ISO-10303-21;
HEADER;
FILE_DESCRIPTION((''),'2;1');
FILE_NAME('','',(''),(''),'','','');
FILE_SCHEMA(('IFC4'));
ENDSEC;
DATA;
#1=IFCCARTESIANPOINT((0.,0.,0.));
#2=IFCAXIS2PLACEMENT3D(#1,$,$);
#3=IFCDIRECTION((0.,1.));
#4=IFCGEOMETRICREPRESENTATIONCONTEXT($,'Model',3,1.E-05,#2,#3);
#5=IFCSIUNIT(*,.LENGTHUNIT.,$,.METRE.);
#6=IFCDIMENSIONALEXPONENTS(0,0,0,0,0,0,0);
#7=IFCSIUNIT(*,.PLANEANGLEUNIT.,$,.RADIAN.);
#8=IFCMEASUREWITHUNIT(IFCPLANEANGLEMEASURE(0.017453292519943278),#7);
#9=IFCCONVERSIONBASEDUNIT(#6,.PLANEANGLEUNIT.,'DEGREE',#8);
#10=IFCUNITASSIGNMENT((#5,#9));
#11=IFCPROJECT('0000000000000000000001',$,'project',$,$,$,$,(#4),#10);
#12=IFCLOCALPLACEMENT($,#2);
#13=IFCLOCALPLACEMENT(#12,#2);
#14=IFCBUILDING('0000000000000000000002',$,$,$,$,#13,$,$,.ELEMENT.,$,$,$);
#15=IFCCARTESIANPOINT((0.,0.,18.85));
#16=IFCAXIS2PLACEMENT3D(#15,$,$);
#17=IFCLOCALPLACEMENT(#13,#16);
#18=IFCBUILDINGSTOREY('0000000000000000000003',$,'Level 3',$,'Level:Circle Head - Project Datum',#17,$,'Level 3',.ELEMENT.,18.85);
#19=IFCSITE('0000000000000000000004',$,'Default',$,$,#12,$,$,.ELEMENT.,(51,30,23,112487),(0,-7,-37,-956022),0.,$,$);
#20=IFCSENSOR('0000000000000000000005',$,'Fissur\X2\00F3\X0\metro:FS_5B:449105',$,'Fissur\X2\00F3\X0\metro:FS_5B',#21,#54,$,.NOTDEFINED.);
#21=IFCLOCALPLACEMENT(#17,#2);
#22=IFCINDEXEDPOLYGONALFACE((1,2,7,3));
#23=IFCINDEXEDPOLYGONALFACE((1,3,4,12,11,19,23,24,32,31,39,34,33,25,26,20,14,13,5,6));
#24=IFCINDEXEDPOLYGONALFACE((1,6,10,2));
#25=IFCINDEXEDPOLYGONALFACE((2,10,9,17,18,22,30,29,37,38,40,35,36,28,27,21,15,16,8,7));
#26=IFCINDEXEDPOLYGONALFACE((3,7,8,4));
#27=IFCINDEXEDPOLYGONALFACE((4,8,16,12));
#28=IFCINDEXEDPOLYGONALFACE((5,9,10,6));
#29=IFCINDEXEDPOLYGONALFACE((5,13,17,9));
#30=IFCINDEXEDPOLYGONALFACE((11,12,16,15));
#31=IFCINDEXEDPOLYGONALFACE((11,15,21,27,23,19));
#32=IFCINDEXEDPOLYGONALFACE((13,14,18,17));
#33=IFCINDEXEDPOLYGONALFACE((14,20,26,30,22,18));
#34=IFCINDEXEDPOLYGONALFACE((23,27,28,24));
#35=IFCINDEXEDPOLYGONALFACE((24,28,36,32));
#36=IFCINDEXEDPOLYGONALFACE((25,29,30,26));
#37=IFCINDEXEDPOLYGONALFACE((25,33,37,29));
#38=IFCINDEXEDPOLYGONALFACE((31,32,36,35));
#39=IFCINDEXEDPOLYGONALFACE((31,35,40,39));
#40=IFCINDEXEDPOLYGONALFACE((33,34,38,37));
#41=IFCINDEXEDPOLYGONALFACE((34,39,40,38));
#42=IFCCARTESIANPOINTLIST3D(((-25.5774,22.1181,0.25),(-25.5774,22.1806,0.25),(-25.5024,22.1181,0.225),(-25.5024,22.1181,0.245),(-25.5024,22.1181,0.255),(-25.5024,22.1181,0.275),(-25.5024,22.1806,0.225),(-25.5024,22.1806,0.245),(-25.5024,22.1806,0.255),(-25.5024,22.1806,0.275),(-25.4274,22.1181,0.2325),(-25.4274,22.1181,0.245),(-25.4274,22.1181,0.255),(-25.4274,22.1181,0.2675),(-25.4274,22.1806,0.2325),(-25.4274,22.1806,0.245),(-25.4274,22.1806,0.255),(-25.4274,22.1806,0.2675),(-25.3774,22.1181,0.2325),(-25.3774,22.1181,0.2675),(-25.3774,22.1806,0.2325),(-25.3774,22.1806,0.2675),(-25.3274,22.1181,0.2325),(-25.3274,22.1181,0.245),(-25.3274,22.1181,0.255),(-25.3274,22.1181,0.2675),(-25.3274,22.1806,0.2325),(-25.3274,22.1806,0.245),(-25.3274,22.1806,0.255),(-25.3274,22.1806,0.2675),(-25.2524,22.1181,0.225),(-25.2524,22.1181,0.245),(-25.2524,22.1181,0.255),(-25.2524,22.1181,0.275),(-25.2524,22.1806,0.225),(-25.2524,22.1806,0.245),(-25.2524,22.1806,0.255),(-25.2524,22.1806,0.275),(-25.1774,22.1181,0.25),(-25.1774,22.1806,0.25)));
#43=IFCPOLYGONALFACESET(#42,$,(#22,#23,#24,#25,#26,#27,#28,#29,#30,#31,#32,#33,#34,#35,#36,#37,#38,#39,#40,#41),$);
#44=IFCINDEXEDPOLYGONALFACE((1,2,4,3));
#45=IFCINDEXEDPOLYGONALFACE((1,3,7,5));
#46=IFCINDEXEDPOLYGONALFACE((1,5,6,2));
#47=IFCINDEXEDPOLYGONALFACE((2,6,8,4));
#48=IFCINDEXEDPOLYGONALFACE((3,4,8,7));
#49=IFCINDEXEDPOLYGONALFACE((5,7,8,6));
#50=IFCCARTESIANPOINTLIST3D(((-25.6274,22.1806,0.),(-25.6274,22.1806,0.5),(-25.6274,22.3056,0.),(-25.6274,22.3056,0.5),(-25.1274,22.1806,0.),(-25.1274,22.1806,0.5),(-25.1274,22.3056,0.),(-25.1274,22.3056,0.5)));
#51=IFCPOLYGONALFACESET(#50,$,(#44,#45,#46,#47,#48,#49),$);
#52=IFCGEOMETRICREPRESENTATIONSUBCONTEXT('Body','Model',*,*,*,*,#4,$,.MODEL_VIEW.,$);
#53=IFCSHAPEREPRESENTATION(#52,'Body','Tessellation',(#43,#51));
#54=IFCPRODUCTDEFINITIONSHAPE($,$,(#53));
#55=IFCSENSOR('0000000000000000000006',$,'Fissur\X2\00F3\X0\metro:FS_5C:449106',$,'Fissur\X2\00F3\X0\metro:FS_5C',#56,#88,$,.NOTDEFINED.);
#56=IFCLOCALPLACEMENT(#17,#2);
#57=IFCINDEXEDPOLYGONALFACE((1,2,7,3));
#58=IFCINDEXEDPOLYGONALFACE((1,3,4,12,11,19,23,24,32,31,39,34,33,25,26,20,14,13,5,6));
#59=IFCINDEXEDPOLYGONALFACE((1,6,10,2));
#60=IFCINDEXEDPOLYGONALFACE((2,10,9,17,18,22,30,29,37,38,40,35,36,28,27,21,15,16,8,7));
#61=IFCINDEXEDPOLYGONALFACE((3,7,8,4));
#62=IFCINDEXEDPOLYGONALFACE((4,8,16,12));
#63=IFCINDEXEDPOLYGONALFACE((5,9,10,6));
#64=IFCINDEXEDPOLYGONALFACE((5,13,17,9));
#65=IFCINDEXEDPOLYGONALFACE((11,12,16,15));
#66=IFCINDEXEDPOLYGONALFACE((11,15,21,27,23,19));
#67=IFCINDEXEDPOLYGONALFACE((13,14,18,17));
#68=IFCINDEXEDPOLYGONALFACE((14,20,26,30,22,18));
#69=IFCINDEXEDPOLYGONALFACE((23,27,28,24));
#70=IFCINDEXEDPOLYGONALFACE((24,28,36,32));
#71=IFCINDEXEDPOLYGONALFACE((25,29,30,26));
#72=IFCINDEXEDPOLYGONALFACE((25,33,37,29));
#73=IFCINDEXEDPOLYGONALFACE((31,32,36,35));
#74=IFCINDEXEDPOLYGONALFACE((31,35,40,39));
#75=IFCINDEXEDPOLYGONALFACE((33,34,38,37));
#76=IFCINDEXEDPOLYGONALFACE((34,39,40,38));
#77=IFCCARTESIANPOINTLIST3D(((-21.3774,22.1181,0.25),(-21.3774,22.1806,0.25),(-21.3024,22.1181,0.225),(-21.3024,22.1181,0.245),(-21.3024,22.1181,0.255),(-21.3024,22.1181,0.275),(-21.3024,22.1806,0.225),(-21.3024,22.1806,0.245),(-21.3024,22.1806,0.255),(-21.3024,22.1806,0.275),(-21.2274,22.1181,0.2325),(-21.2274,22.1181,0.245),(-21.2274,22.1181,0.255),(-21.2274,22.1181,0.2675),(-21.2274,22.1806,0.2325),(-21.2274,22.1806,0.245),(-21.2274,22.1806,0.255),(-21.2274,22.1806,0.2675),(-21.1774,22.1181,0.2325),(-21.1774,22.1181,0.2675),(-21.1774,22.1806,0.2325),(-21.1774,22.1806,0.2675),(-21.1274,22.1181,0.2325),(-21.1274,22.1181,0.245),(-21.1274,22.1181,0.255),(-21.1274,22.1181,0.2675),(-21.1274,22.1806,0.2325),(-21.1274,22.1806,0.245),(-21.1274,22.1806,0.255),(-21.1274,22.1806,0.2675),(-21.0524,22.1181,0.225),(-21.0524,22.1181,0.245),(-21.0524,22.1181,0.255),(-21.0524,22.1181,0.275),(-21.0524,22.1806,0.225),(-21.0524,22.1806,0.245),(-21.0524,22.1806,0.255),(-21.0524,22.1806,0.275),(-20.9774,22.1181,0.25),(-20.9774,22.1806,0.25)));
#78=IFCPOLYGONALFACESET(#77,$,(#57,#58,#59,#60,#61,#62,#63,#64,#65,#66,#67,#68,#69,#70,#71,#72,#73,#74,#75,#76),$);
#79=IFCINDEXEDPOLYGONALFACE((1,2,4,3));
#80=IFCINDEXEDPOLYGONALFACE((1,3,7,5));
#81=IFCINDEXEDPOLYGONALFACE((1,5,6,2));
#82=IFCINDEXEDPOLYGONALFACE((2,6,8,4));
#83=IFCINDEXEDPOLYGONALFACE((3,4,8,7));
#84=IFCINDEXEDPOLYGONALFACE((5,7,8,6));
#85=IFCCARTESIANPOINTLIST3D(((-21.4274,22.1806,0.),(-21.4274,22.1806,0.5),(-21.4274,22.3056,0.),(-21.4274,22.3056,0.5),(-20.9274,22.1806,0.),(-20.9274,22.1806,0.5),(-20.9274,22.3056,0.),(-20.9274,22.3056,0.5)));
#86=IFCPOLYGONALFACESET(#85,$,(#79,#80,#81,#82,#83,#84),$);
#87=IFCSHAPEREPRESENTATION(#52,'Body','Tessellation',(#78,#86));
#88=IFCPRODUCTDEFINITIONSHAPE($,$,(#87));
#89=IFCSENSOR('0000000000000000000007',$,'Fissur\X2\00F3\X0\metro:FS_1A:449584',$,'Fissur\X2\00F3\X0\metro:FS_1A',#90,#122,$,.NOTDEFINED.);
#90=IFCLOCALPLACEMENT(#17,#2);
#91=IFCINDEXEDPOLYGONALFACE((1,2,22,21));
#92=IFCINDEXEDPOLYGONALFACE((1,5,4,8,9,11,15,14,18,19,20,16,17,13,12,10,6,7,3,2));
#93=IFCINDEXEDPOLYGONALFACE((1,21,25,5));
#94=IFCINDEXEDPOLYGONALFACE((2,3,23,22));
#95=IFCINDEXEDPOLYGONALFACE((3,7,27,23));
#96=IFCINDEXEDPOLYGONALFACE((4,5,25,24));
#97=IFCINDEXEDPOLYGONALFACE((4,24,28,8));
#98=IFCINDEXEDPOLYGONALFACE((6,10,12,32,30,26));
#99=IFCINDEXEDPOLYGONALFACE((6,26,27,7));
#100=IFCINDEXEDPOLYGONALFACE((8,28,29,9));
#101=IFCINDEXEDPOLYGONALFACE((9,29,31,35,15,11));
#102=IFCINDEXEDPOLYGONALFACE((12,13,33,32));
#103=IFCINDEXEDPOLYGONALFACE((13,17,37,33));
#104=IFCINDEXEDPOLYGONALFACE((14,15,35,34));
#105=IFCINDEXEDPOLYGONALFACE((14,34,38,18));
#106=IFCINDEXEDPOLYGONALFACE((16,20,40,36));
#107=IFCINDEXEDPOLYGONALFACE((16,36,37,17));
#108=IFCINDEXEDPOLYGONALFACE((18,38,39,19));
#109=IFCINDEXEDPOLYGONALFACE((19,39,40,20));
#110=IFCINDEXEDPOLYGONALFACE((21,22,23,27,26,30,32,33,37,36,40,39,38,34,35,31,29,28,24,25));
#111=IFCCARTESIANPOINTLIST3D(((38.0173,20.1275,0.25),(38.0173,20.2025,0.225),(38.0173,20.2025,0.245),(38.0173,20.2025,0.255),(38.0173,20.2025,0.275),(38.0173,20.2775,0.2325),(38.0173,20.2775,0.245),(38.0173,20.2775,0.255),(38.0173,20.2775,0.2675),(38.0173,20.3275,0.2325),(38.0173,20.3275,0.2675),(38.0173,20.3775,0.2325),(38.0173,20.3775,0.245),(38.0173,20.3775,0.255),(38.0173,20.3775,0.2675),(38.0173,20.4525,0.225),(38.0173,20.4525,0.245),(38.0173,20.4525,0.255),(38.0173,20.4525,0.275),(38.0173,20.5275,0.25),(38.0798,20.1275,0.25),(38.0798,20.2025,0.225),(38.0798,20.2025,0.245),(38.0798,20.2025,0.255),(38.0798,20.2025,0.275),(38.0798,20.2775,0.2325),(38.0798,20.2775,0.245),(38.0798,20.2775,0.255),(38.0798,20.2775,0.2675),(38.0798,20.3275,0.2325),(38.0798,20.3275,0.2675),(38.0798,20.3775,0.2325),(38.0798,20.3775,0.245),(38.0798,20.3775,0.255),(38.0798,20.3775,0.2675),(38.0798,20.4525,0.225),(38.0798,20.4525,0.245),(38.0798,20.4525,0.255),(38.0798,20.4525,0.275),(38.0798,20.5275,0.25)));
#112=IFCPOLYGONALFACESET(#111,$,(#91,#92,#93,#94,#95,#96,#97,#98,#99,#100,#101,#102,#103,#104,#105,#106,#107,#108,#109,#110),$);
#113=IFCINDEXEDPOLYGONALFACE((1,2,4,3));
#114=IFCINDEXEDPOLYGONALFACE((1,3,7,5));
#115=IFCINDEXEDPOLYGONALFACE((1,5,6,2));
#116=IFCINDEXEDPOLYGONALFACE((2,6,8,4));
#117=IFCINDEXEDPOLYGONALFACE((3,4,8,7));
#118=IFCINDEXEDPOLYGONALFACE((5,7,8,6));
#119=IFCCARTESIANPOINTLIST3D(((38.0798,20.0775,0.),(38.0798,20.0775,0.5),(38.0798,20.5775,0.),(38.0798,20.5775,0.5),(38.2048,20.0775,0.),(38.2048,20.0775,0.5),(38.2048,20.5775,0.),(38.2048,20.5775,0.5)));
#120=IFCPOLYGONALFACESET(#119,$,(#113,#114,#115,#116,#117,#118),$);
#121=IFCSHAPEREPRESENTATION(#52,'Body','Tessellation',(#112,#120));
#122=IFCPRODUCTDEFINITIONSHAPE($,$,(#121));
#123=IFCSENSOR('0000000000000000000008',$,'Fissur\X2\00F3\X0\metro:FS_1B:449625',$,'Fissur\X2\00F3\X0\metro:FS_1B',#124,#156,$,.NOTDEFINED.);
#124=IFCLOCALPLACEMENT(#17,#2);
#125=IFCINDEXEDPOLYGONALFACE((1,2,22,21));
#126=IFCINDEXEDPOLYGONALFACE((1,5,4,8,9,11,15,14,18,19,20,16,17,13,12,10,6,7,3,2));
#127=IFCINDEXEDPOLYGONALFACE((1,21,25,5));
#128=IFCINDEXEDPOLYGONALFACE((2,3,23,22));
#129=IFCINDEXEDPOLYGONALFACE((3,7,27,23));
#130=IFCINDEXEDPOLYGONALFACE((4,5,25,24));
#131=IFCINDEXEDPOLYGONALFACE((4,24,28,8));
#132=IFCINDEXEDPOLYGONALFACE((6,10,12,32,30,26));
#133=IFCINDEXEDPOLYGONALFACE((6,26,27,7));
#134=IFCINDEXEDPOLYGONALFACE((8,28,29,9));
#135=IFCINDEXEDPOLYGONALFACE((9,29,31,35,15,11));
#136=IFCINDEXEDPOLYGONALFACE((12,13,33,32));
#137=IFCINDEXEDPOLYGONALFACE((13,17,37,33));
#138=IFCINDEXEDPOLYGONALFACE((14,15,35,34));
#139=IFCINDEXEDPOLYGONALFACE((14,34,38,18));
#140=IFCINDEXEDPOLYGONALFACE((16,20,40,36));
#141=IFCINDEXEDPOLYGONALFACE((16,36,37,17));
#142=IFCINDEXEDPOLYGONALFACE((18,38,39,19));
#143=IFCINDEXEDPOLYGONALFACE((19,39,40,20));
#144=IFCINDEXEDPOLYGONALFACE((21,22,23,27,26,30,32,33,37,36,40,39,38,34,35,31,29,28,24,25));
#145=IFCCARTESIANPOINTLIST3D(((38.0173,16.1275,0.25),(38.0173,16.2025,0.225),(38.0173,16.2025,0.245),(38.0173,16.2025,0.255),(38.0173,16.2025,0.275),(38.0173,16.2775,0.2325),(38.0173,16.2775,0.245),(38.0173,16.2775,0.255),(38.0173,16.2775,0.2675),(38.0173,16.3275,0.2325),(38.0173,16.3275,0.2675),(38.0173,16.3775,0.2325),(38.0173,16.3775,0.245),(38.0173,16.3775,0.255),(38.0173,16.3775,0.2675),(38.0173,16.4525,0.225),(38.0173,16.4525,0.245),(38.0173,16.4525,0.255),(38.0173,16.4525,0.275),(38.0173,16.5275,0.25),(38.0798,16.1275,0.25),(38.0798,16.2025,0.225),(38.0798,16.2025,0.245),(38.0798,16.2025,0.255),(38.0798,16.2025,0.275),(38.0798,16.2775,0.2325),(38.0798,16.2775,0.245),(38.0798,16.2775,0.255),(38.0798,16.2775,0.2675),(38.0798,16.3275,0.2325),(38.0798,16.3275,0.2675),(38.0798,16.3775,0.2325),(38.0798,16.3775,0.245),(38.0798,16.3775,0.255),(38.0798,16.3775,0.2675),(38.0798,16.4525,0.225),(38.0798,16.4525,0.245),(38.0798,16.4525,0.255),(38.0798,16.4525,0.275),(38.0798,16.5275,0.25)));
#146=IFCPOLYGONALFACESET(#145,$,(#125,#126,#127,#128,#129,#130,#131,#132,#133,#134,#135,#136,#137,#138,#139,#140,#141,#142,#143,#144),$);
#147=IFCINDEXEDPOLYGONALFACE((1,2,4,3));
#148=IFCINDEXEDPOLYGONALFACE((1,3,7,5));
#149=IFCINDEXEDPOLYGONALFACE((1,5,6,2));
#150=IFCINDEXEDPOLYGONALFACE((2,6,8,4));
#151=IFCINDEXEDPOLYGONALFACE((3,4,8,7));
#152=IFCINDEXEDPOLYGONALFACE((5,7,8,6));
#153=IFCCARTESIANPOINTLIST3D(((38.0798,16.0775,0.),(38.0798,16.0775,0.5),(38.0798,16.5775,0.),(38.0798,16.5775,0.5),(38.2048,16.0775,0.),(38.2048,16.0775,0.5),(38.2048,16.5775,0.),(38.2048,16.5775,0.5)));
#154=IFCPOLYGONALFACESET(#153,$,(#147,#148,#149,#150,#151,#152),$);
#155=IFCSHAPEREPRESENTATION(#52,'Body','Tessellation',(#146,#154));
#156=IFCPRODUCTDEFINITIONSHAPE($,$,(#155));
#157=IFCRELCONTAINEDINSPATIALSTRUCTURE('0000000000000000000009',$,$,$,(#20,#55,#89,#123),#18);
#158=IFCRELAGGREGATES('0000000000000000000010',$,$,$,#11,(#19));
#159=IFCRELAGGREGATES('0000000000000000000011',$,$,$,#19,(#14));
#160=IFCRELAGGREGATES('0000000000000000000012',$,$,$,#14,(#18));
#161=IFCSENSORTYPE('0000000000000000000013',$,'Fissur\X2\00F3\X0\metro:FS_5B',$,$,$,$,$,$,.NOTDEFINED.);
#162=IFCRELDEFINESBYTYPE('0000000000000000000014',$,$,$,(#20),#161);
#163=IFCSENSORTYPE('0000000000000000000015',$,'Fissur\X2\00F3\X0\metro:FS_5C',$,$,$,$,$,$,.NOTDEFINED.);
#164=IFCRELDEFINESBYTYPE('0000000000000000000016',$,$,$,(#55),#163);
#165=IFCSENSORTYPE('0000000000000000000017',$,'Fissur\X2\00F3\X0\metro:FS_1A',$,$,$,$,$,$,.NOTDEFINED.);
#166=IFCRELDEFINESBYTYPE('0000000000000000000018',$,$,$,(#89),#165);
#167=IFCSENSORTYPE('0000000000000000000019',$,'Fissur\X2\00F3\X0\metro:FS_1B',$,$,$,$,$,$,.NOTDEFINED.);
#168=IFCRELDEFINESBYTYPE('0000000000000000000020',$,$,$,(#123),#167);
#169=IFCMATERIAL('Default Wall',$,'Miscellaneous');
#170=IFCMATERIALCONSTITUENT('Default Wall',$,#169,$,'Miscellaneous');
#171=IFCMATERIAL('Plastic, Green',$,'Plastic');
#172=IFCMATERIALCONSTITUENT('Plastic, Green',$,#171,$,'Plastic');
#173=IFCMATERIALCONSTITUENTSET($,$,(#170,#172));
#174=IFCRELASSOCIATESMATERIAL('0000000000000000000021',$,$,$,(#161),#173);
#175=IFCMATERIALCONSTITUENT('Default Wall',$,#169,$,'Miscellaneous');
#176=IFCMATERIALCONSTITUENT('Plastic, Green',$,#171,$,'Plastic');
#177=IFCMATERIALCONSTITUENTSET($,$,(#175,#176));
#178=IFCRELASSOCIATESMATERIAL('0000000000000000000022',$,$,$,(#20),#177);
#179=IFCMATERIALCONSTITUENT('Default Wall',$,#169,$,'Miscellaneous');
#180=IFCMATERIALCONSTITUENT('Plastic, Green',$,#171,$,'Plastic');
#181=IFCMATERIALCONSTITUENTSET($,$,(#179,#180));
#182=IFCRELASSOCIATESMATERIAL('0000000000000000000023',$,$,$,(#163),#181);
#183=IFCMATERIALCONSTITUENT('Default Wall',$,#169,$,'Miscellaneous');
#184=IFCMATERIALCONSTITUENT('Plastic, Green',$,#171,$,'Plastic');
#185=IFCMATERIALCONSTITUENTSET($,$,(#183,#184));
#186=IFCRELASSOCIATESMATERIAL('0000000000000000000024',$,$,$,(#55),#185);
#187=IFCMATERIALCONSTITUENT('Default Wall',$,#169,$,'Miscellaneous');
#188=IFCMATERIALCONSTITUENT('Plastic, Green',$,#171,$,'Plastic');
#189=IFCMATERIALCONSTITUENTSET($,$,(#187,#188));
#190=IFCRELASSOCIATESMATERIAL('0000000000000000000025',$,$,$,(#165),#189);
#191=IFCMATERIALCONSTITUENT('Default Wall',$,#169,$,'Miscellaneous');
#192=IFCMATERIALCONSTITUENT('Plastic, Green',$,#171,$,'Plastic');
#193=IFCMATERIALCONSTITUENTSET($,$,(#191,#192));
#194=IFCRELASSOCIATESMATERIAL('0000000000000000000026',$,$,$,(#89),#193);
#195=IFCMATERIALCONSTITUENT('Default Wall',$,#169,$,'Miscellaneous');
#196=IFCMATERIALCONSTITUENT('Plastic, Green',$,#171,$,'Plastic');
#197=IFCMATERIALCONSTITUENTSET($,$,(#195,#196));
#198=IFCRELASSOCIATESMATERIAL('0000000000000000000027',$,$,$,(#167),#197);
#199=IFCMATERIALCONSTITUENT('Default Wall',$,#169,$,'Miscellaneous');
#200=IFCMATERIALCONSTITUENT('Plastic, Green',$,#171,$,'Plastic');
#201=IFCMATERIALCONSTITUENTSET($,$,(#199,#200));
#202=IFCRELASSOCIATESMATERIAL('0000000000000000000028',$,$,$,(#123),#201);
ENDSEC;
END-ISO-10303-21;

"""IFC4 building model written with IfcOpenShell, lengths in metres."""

from ifc_helpers import new_model, entity, si_unit, converted_unit, direction, frame, origin, place, context, subcontext, project, spatial, indexed_curve, outline, extrude, source, transform, mapped, material, constituent, constituent_set, type_object, type_shapes, element, save


model = new_model("IFC4")

# Units and contexts
model_context = context("Model", 3, precision=1e-05, world=origin(), true_north=direction((0.0, 1.0)))
body_context = subcontext(model_context, "Body", "Model", "MODEL_VIEW")
ifc_project = project(units=[si_unit("LENGTHUNIT", "METRE"), converted_unit("PLANEANGLEUNIT", "DEGREE", entity("IfcPlaneAngleMeasure", 0.017453292519943278), si_unit("PLANEANGLEUNIT", "RADIAN"), dimensions=[0, 0, 0, 0, 0, 0, 0])], contexts=[model_context])

# Site, building, storey
site_placement = place(None, origin())
site = spatial("IfcSite", under=ifc_project, at=site_placement, Name="Default", CompositionType="ELEMENT", RefLatitude=(51, 30, 23, 112487), RefLongitude=(0, -7, -37, -956022), RefElevation=0.0)
building_placement = place(site_placement, origin())
building = spatial("IfcBuilding", under=site, at=building_placement, CompositionType="ELEMENT")
storey_placement = place(building_placement, frame((0.0, 0.0, 18.85)))
storey = spatial("IfcBuildingStorey", under=building, at=storey_placement, Name="Level 3", ObjectType="Level:Circle Head - Project Datum", LongName="Level 3", CompositionType="ELEMENT", Elevation=18.85)

# Sensors
ifc_material_1 = material(Name="Default Wall", Category="Miscellaneous")
ifc_material_2 = material(Name="Plastic, Green", Category="Plastic")
ifc_constituent_1 = constituent(ifc_material_1, Name="Default Wall", Category="Miscellaneous")
ifc_constituent_2 = constituent(ifc_material_2, Name="Plastic, Green", Category="Plastic")
ifc_constituent_set_1 = constituent_set(constituents=[ifc_constituent_1, ifc_constituent_2])
ifc_constituent_3 = constituent(ifc_material_1, Name="Default Wall", Category="Miscellaneous")
ifc_constituent_4 = constituent(ifc_material_2, Name="Plastic, Green", Category="Plastic")
ifc_constituent_set_2 = constituent_set(constituents=[ifc_constituent_3, ifc_constituent_4])
sensor_type_1 = type_object("IfcSensorType", Name="Fissurómetro:FS_5B", PredefinedType="NOTDEFINED", material=ifc_constituent_set_2)
shared_shape_1 = source(origin(), body_context, "Body", "SweptSolid", [
    extrude(outline(indexed_curve([(-0.025, -0.125), (0.0, -0.2), (0.025, -0.125), (0.005, -0.125), (0.005, -0.05), (0.0175, -0.05), (0.0175, 0.0), (0.0175, 0.05), (0.005, 0.05), (0.005, 0.125), (0.025, 0.125), (0.0, 0.2), (-0.025, 0.125), (-0.005, 0.125), (-0.005, 0.05), (-0.0175, 0.05), (-0.0175, 0.0), (-0.0175, -0.05), (-0.005, -0.05), (-0.005, -0.125), (-0.025, -0.125)], self_intersect=False)), frame((0.0, -0.125, 0.25), z_axis=(0.0, -1.0, 0.0), x_axis=(0.0, 0.0, -1.0)), (0.0, 0.0, -1.0), 0.0625),
    extrude(outline(indexed_curve([(-0.25, -0.0625), (0.25, -0.0625), (0.25, 0.0625), (-0.25, 0.0625), (-0.25, -0.0625)], self_intersect=False)), frame((0.0, 0.0, 0.0), z_axis=(0.0, 0.0, 1.0), x_axis=(-1.0, 0.0, 0.0)), (0.0, 0.0, 1.0), 0.5),
])
type_shapes(sensor_type_1, [shared_shape_1])
sensor_1_placement = place(storey_placement, frame((-25.3774, 22.2431, 0.0)))
element("IfcSensor", 1, at=sensor_1_placement, inside=storey, type_object=sensor_type_1, material=ifc_constituent_set_1, Name="Fissurómetro:FS_5B:449105", ObjectType="Fissurómetro:FS_5B", PredefinedType="NOTDEFINED", context=body_context, shape_type="MappedRepresentation", body=[
    mapped(shared_shape_1, transform((0.0, 0.0, 0.0), scale=1.0)),
])
ifc_constituent_5 = constituent(ifc_material_1, Name="Default Wall", Category="Miscellaneous")
ifc_constituent_6 = constituent(ifc_material_2, Name="Plastic, Green", Category="Plastic")
ifc_constituent_set_3 = constituent_set(constituents=[ifc_constituent_5, ifc_constituent_6])
ifc_constituent_7 = constituent(ifc_material_1, Name="Default Wall", Category="Miscellaneous")
ifc_constituent_8 = constituent(ifc_material_2, Name="Plastic, Green", Category="Plastic")
ifc_constituent_set_4 = constituent_set(constituents=[ifc_constituent_7, ifc_constituent_8])
sensor_type_2 = type_object("IfcSensorType", Name="Fissurómetro:FS_5C", PredefinedType="NOTDEFINED", material=ifc_constituent_set_4)
shared_shape_2 = source(origin(), body_context, "Body", "SweptSolid", [
    extrude(outline(indexed_curve([(-0.025, -0.125), (0.0, -0.2), (0.025, -0.125), (0.005, -0.125), (0.005, -0.05), (0.0175, -0.05), (0.0175, 0.0), (0.0175, 0.05), (0.005, 0.05), (0.005, 0.125), (0.025, 0.125), (0.0, 0.2), (-0.025, 0.125), (-0.005, 0.125), (-0.005, 0.05), (-0.0175, 0.05), (-0.0175, 0.0), (-0.0175, -0.05), (-0.005, -0.05), (-0.005, -0.125), (-0.025, -0.125)], self_intersect=False)), frame((0.0, -0.125, 0.25), z_axis=(0.0, -1.0, 0.0), x_axis=(0.0, 0.0, -1.0)), (0.0, 0.0, -1.0), 0.0625),
    extrude(outline(indexed_curve([(-0.25, -0.0625), (0.25, -0.0625), (0.25, 0.0625), (-0.25, 0.0625), (-0.25, -0.0625)], self_intersect=False)), frame((0.0, 0.0, 0.0), z_axis=(0.0, 0.0, 1.0), x_axis=(-1.0, 0.0, 0.0)), (0.0, 0.0, 1.0), 0.5),
])
type_shapes(sensor_type_2, [shared_shape_2])
sensor_2_placement = place(storey_placement, frame((-21.1774, 22.2431, 0.0)))
element("IfcSensor", 2, at=sensor_2_placement, inside=storey, type_object=sensor_type_2, material=ifc_constituent_set_3, Name="Fissurómetro:FS_5C:449106", ObjectType="Fissurómetro:FS_5C", PredefinedType="NOTDEFINED", context=body_context, shape_type="MappedRepresentation", body=[
    mapped(shared_shape_2, transform((0.0, 0.0, 0.0), scale=1.0)),
])
ifc_constituent_9 = constituent(ifc_material_1, Name="Default Wall", Category="Miscellaneous")
ifc_constituent_10 = constituent(ifc_material_2, Name="Plastic, Green", Category="Plastic")
ifc_constituent_set_5 = constituent_set(constituents=[ifc_constituent_9, ifc_constituent_10])
ifc_constituent_11 = constituent(ifc_material_1, Name="Default Wall", Category="Miscellaneous")
ifc_constituent_12 = constituent(ifc_material_2, Name="Plastic, Green", Category="Plastic")
ifc_constituent_set_6 = constituent_set(constituents=[ifc_constituent_11, ifc_constituent_12])
sensor_type_3 = type_object("IfcSensorType", Name="Fissurómetro:FS_1A", PredefinedType="NOTDEFINED", material=ifc_constituent_set_6)
shared_shape_3 = source(origin(), body_context, "Body", "SweptSolid", [
    extrude(outline(indexed_curve([(-0.025, -0.125), (0.0, -0.2), (0.025, -0.125), (0.005, -0.125), (0.005, -0.05), (0.0175, -0.05), (0.0175, 0.0), (0.0175, 0.05), (0.005, 0.05), (0.005, 0.125), (0.025, 0.125), (0.0, 0.2), (-0.025, 0.125), (-0.005, 0.125), (-0.005, 0.05), (-0.0175, 0.05), (-0.0175, 0.0), (-0.0175, -0.05), (-0.005, -0.05), (-0.005, -0.125), (-0.025, -0.125)], self_intersect=False)), frame((0.0, -0.125, 0.25), z_axis=(0.0, -1.0, 0.0), x_axis=(0.0, 0.0, -1.0)), (0.0, 0.0, -1.0), 0.0625),
    extrude(outline(indexed_curve([(-0.25, -0.0625), (0.25, -0.0625), (0.25, 0.0625), (-0.25, 0.0625), (-0.25, -0.0625)], self_intersect=False)), frame((0.0, 0.0, 0.0), z_axis=(0.0, 0.0, 1.0), x_axis=(-1.0, 0.0, 0.0)), (0.0, 0.0, 1.0), 0.5),
])
type_shapes(sensor_type_3, [shared_shape_3])
sensor_3_placement = place(storey_placement, frame((38.1423, 20.3275, 0.0), z_axis=(0.0, 0.0, 1.0), x_axis=(0.0, -1.0, 0.0)))
element("IfcSensor", 3, at=sensor_3_placement, inside=storey, type_object=sensor_type_3, material=ifc_constituent_set_5, Name="Fissurómetro:FS_1A:449584", ObjectType="Fissurómetro:FS_1A", PredefinedType="NOTDEFINED", context=body_context, shape_type="MappedRepresentation", body=[
    mapped(shared_shape_3, transform((0.0, 0.0, 0.0), scale=1.0)),
])
ifc_constituent_13 = constituent(ifc_material_1, Name="Default Wall", Category="Miscellaneous")
ifc_constituent_14 = constituent(ifc_material_2, Name="Plastic, Green", Category="Plastic")
ifc_constituent_set_7 = constituent_set(constituents=[ifc_constituent_13, ifc_constituent_14])
ifc_constituent_15 = constituent(ifc_material_1, Name="Default Wall", Category="Miscellaneous")
ifc_constituent_16 = constituent(ifc_material_2, Name="Plastic, Green", Category="Plastic")
ifc_constituent_set_8 = constituent_set(constituents=[ifc_constituent_15, ifc_constituent_16])
sensor_type_4 = type_object("IfcSensorType", Name="Fissurómetro:FS_1B", PredefinedType="NOTDEFINED", material=ifc_constituent_set_8)
shared_shape_4 = source(origin(), body_context, "Body", "SweptSolid", [
    extrude(outline(indexed_curve([(-0.025, -0.125), (0.0, -0.2), (0.025, -0.125), (0.005, -0.125), (0.005, -0.05), (0.0175, -0.05), (0.0175, 0.0), (0.0175, 0.05), (0.005, 0.05), (0.005, 0.125), (0.025, 0.125), (0.0, 0.2), (-0.025, 0.125), (-0.005, 0.125), (-0.005, 0.05), (-0.0175, 0.05), (-0.0175, 0.0), (-0.0175, -0.05), (-0.005, -0.05), (-0.005, -0.125), (-0.025, -0.125)], self_intersect=False)), frame((0.0, -0.125, 0.25), z_axis=(0.0, -1.0, 0.0), x_axis=(0.0, 0.0, -1.0)), (0.0, 0.0, -1.0), 0.0625),
    extrude(outline(indexed_curve([(-0.25, -0.0625), (0.25, -0.0625), (0.25, 0.0625), (-0.25, 0.0625), (-0.25, -0.0625)], self_intersect=False)), frame((0.0, 0.0, 0.0), z_axis=(0.0, 0.0, 1.0), x_axis=(-1.0, 0.0, 0.0)), (0.0, 0.0, 1.0), 0.5),
])
type_shapes(sensor_type_4, [shared_shape_4])
sensor_4_placement = place(storey_placement, frame((38.1423, 16.3275, 0.0), z_axis=(0.0, 0.0, 1.0), x_axis=(0.0, -1.0, 0.0)))
element("IfcSensor", 4, at=sensor_4_placement, inside=storey, type_object=sensor_type_4, material=ifc_constituent_set_7, Name="Fissurómetro:FS_1B:449625", ObjectType="Fissurómetro:FS_1B", PredefinedType="NOTDEFINED", context=body_context, shape_type="MappedRepresentation", body=[
    mapped(shared_shape_4, transform((0.0, 0.0, 0.0), scale=1.0)),
])

save(model, "model.ifc")
